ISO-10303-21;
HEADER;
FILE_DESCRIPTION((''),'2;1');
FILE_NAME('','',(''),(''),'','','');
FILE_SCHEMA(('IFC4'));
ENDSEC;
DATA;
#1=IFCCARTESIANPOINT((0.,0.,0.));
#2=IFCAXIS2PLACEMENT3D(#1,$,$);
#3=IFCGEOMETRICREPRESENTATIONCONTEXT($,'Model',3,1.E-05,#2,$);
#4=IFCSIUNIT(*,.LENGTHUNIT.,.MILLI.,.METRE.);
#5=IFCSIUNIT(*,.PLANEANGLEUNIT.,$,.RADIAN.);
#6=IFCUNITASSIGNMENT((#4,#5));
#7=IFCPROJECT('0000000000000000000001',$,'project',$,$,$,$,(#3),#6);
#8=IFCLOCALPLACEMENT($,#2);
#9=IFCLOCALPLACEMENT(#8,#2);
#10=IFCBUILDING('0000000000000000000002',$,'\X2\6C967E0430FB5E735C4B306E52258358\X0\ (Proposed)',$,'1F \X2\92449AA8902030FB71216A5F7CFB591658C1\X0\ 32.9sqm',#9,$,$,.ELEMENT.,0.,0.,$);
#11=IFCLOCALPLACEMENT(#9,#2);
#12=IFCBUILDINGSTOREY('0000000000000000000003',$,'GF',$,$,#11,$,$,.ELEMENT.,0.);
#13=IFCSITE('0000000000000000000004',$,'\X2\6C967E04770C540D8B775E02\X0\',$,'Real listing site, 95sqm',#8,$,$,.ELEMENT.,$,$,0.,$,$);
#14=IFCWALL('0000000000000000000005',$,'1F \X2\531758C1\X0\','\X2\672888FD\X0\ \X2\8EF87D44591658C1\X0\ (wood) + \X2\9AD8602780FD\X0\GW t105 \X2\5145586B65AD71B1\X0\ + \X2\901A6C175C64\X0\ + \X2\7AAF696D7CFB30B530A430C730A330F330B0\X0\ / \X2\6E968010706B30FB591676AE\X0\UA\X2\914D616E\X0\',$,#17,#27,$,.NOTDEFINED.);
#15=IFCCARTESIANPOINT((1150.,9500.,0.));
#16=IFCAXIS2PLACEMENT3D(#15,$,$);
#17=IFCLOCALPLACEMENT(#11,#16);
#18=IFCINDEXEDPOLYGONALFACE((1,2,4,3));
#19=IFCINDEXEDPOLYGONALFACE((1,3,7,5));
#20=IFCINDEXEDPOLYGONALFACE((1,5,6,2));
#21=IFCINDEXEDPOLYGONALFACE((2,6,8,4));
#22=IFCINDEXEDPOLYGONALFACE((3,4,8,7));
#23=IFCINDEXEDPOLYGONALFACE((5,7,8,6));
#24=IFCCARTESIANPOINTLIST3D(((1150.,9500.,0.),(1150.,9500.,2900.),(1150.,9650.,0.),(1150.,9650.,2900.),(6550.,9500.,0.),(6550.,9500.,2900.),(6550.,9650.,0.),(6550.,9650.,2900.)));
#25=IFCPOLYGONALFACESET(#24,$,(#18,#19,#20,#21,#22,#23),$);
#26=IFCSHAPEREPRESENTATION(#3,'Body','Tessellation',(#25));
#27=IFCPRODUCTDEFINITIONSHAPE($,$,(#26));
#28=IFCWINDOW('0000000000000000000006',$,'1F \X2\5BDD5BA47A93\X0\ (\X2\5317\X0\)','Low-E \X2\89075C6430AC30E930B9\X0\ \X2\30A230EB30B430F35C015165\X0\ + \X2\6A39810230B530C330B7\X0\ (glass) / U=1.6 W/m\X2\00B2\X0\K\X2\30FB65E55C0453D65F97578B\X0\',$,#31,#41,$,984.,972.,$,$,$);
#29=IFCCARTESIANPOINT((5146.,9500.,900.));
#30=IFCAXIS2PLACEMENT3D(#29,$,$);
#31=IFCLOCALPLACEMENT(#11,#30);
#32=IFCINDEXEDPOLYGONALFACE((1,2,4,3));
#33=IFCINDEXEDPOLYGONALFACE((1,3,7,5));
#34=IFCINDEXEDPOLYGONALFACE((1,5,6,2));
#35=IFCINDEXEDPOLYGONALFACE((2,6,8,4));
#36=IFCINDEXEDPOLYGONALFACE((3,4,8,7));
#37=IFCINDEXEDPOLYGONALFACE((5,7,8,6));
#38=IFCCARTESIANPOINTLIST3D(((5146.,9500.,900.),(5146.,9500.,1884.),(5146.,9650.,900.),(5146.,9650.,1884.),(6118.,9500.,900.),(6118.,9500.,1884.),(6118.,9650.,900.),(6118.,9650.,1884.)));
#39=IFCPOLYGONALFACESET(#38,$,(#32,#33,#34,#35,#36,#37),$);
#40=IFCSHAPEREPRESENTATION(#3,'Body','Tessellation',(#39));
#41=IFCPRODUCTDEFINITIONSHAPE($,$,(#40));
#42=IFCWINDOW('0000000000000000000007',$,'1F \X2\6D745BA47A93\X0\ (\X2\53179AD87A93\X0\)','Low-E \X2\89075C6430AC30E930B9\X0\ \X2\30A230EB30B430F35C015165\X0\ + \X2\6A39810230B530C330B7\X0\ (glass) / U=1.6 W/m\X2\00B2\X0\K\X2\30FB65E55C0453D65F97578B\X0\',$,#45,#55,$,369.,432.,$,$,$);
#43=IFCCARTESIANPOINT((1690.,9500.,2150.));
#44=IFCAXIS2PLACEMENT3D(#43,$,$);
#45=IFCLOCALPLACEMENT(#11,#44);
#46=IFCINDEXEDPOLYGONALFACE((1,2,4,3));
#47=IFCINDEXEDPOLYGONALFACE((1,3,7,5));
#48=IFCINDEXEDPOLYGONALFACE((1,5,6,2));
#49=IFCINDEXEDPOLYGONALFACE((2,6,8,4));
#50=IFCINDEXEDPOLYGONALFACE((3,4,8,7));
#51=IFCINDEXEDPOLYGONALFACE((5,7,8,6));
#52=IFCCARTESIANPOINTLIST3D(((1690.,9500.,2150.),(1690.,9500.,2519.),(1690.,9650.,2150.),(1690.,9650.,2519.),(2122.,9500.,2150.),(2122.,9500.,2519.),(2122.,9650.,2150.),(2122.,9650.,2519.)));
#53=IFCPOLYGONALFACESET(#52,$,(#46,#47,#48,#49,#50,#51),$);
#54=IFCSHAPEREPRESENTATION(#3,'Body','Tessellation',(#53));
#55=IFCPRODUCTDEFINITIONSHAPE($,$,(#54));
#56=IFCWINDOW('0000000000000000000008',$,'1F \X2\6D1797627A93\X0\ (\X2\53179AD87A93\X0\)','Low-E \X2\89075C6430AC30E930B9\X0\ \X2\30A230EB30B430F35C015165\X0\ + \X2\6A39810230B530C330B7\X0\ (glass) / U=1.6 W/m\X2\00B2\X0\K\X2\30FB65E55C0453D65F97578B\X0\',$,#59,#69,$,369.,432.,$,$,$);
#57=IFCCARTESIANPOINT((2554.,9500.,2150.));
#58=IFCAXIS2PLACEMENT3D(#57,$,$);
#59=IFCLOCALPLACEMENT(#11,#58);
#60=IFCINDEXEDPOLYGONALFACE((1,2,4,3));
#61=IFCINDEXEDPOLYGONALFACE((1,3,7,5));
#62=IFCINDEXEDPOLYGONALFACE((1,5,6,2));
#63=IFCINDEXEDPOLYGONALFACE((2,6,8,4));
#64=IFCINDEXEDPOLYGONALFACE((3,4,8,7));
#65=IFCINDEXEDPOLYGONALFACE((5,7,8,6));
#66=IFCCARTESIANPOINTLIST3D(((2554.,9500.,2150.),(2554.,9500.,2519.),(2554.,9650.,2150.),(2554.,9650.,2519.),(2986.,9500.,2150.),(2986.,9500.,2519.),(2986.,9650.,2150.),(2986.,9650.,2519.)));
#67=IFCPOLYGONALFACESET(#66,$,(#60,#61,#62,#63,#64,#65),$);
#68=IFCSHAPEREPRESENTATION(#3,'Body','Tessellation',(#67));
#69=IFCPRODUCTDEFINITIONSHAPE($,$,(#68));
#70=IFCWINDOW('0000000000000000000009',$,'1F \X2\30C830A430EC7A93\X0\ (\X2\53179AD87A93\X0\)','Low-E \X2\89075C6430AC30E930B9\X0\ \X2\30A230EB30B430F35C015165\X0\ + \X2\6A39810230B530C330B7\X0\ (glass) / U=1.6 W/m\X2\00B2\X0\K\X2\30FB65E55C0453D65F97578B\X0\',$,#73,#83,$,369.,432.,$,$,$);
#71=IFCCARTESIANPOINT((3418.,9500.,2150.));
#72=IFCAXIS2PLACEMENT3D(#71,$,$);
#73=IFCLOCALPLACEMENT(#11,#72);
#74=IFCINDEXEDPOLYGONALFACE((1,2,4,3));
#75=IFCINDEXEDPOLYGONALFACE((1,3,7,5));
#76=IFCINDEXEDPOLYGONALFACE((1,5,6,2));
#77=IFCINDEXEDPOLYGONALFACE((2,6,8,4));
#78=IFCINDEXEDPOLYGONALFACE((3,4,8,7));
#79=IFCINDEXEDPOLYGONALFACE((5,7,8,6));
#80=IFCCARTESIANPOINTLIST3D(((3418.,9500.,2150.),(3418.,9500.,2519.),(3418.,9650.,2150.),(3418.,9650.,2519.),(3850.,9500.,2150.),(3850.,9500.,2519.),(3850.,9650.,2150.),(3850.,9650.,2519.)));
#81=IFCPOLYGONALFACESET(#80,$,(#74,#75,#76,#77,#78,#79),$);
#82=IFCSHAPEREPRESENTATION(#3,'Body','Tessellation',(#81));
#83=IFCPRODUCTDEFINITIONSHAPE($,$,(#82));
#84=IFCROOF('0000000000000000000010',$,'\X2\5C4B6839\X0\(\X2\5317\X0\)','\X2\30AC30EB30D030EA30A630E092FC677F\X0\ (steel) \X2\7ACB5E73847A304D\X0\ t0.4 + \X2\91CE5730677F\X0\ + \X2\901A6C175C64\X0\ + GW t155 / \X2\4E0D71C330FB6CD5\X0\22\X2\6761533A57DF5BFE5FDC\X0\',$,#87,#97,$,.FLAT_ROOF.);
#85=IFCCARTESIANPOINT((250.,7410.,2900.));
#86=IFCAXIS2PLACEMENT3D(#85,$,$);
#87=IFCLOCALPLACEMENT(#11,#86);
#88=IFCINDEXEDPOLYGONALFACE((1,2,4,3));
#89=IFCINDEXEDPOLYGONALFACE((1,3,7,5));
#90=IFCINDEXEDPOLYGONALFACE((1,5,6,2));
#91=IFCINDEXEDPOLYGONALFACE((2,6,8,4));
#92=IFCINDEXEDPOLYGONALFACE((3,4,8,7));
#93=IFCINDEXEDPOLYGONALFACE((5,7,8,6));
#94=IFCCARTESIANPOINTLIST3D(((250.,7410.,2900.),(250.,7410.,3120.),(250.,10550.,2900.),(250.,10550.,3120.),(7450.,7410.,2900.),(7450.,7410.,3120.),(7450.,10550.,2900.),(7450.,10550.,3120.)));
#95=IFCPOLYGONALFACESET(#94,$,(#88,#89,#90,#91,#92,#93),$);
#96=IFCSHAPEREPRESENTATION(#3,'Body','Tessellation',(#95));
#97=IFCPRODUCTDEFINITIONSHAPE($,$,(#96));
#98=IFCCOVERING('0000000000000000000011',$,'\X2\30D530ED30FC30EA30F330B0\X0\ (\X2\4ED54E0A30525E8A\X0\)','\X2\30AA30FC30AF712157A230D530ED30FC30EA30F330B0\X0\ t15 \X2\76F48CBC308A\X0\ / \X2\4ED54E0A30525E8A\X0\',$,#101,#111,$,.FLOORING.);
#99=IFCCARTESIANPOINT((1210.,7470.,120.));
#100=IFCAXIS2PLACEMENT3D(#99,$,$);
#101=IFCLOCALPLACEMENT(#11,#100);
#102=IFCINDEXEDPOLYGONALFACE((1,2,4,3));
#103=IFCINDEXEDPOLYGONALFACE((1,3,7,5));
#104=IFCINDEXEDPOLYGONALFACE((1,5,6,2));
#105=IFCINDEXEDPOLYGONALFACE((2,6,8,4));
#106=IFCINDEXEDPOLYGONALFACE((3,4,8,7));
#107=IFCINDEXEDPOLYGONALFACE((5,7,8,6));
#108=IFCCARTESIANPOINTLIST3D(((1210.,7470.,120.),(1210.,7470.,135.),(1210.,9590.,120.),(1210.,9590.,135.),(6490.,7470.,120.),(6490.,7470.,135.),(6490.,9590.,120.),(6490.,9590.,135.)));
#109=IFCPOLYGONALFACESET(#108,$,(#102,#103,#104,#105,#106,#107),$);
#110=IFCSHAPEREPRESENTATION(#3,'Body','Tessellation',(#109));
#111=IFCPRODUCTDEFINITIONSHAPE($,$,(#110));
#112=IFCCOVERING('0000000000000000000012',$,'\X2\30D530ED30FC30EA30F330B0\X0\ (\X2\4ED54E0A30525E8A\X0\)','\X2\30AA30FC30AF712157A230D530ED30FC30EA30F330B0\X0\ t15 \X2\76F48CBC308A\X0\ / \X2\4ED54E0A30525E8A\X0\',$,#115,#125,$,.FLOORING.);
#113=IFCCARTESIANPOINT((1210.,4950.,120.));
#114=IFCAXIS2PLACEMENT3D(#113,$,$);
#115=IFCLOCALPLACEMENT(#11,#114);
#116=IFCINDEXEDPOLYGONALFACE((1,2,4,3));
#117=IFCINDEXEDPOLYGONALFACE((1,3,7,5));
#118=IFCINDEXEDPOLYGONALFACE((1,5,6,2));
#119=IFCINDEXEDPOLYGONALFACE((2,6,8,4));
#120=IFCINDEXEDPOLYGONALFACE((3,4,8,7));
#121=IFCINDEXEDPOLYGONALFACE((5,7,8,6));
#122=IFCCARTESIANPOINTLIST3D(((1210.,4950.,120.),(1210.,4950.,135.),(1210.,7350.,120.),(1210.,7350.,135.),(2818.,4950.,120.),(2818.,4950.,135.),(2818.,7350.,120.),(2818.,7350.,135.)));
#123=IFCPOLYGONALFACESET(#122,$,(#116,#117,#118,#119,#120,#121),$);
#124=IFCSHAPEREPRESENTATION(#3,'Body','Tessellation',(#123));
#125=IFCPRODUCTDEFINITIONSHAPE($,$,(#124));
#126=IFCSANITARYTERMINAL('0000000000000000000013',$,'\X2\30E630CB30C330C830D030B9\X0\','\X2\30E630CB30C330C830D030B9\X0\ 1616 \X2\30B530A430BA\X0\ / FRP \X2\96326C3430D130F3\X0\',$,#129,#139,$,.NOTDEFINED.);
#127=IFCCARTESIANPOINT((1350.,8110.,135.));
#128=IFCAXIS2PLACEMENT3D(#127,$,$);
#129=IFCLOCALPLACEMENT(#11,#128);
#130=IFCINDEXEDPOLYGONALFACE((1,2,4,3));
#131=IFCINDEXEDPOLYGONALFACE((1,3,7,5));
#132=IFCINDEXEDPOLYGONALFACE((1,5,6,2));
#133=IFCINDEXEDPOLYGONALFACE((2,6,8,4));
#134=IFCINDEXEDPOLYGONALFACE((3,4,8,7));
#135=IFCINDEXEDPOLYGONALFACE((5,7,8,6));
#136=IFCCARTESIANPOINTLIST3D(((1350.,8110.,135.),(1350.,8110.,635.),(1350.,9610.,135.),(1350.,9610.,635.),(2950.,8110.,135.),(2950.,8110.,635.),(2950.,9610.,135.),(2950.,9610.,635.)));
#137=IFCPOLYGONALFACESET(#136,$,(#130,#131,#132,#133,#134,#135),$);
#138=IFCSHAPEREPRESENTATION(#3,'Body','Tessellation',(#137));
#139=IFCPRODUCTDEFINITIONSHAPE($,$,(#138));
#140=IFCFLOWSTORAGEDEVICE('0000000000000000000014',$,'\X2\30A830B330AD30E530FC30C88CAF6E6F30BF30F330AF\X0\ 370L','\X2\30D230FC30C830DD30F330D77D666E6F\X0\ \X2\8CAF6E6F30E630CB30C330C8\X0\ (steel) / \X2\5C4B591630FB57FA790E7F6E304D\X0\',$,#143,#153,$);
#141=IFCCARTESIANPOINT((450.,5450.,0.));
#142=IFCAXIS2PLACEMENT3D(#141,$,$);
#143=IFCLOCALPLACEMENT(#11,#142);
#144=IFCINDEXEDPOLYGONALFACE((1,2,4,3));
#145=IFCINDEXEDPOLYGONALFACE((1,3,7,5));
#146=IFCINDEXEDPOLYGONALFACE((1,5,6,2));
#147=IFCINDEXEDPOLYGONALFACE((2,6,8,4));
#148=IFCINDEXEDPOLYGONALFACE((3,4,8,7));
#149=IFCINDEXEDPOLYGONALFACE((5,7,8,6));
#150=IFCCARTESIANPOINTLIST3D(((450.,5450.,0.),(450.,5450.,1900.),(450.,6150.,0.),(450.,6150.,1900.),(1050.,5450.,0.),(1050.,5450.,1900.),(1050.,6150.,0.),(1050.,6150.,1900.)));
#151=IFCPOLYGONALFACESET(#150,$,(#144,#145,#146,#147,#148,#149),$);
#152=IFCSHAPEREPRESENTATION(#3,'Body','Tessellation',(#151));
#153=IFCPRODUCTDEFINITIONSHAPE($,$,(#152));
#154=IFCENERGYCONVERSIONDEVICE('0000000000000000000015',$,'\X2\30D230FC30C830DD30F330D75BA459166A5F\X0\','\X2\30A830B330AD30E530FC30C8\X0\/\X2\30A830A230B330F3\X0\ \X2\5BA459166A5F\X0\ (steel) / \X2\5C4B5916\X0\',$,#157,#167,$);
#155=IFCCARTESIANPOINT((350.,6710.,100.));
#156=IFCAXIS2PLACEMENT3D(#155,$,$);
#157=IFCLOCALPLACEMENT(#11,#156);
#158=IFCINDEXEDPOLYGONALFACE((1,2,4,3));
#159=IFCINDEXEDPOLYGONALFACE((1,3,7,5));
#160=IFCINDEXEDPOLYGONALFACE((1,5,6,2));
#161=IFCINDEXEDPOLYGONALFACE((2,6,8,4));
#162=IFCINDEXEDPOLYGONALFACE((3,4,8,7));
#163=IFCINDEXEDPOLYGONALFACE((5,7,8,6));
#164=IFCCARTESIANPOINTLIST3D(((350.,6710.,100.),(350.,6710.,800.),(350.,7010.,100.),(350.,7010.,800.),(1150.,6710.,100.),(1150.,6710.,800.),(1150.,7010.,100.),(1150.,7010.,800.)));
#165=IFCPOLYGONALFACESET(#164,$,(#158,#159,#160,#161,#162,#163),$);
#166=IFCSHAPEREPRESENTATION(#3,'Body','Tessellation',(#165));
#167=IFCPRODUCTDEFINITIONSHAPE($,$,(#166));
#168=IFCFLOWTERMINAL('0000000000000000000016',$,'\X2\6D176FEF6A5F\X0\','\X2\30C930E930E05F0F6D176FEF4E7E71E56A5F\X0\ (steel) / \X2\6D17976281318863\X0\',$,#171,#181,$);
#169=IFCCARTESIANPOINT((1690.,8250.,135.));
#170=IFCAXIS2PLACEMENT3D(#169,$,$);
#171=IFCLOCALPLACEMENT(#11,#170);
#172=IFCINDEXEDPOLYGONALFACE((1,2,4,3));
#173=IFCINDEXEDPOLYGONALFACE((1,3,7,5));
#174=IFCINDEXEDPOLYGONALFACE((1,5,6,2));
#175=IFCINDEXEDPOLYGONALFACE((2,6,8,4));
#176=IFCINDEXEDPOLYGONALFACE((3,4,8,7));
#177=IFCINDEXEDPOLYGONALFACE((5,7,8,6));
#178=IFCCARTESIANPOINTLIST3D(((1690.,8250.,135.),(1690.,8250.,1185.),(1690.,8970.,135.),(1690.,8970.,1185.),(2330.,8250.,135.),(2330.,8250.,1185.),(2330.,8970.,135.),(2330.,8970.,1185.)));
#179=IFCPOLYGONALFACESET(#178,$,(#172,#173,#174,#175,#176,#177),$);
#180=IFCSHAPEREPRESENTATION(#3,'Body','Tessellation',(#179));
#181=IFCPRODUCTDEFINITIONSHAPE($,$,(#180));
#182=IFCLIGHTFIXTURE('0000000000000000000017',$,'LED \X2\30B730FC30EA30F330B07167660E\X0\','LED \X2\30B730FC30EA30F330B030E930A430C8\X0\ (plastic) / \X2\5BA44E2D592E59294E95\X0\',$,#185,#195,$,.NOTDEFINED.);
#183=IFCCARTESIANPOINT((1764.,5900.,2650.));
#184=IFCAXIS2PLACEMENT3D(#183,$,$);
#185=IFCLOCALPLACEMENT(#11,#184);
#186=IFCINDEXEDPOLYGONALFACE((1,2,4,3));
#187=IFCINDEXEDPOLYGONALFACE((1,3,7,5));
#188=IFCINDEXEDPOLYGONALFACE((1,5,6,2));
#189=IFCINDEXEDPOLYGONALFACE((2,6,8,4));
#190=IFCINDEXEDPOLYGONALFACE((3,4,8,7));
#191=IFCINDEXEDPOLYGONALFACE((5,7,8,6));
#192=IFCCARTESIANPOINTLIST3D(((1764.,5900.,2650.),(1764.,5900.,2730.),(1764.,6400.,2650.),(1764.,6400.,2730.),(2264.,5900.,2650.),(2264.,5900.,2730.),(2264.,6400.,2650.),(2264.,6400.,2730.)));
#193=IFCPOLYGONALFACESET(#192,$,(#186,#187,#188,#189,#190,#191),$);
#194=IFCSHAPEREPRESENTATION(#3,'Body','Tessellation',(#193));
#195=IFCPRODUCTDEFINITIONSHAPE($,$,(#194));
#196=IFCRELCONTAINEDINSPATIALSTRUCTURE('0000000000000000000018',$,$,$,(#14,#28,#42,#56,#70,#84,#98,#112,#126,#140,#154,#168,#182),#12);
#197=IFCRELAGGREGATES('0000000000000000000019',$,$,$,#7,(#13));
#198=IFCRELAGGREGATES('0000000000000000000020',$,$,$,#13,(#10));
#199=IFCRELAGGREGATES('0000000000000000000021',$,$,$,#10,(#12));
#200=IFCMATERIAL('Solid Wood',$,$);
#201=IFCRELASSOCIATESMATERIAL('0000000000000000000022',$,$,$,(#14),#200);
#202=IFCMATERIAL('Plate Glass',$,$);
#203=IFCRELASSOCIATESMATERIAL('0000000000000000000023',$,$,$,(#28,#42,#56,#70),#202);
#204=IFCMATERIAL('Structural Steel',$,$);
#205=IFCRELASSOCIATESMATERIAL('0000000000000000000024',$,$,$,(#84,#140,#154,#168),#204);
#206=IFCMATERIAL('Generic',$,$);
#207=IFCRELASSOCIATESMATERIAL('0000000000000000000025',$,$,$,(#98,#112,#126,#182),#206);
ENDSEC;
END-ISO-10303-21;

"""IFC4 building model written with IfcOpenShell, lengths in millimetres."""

from ifc_helpers import new_model, si_unit, frame, frame_2d, origin, place, context, project, spatial, rectangle, extrude, material, element, fill, save


model = new_model("IFC4")

# Units and contexts
model_context = context("Model", 3, precision=1e-05, world=origin())
ifc_project = project(units=[si_unit("LENGTHUNIT", "METRE", prefix="MILLI"), si_unit("PLANEANGLEUNIT", "RADIAN")], contexts=[model_context])

# Site, building, storey
site_placement = place(None, origin())
site = spatial("IfcSite", under=ifc_project, at=site_placement, Name="沖縄県名護市", ObjectType="Real listing site, 95sqm", CompositionType="ELEMENT", RefElevation=0.0)
building_placement = place(site_placement, origin())
building = spatial("IfcBuilding", under=site, at=building_placement, Name="沖縄・平屋の別荘 (Proposed)", ObjectType="1F 鉄骨造・無機系外壁 32.9sqm", CompositionType="ELEMENT", ElevationOfRefHeight=0.0, ElevationOfTerrain=0.0)
storey_placement = place(building_placement, origin())
storey = spatial("IfcBuildingStorey", under=building, at=storey_placement, Name="GF", CompositionType="ELEMENT", Elevation=0.0)

# Shared definitions
ifc_material_1 = material(Name="Solid Wood")

# Wall, openings, windows
wall_1_placement = place(storey_placement, frame((1150.0, 9500.0, 0.0)))
wall_1 = element("IfcWall", 1, at=wall_1_placement, inside=storey, material=ifc_material_1, Name="1F 北壁", Description="木製 軸組外壁 (wood) + 高性能GW t105 充填断熱 + 通気層 + 窯業系サイディング / 準耐火・外皮UA配慮", PredefinedType="NOTDEFINED", context=model_context, shape_type="SweptSolid", body=[
    extrude(rectangle(XDim=5400.0, YDim=150.0, at=frame_2d((2700.0, 75.0))), frame((1150.0, 9500.0, 0.0)), (0.0, 0.0, 1.0), 2900.0),
])
opening_1_placement = place(storey_placement, frame((5146.0, 9500.0, 900.0)))
opening_1 = element("IfcOpeningElement", 2, at=opening_1_placement, cuts=wall_1, PredefinedType="NOTDEFINED", context=model_context, shape_type="SweptSolid", body=[
    extrude(rectangle(XDim=972.0, YDim=150.0, at=frame_2d((486.0, 75.0))), frame((5146.0, 9500.0, 900.0)), (0.0, 0.0, 1.0), 984.0),
])
opening_2_placement = place(storey_placement, frame((1690.0, 9500.0, 2150.0)))
opening_2 = element("IfcOpeningElement", 3, at=opening_2_placement, cuts=wall_1, PredefinedType="NOTDEFINED", context=model_context, shape_type="SweptSolid", body=[
    extrude(rectangle(XDim=432.0, YDim=150.0, at=frame_2d((216.0, 75.0))), frame((1690.0, 9500.0, 2150.0)), (0.0, 0.0, 1.0), 369.0),
])
opening_3_placement = place(storey_placement, frame((2554.0, 9500.0, 2150.0)))
opening_3 = element("IfcOpeningElement", 4, at=opening_3_placement, cuts=wall_1, PredefinedType="NOTDEFINED", context=model_context, shape_type="SweptSolid", body=[
    extrude(rectangle(XDim=432.0, YDim=150.0, at=frame_2d((216.0, 75.0))), frame((2554.0, 9500.0, 2150.0)), (0.0, 0.0, 1.0), 369.0),
])
opening_4_placement = place(storey_placement, frame((3418.0, 9500.0, 2150.0)))
opening_4 = element("IfcOpeningElement", 5, at=opening_4_placement, cuts=wall_1, PredefinedType="NOTDEFINED", context=model_context, shape_type="SweptSolid", body=[
    extrude(rectangle(XDim=432.0, YDim=150.0, at=frame_2d((216.0, 75.0))), frame((3418.0, 9500.0, 2150.0)), (0.0, 0.0, 1.0), 369.0),
])
ifc_material_2 = material(Name="Plate Glass")
window_1_placement = place(storey_placement, frame((5146.0, 9500.0, 900.0)))
window_1 = element("IfcWindow", 6, at=window_1_placement, inside=storey, material=ifc_material_2, Name="1F 寝室窓 (北)", Description="Low-E 複層ガラス アルゴン封入 + 樹脂サッシ (glass) / U=1.6 W/m²K・日射取得型", OverallHeight=984.0, OverallWidth=972.0, context=model_context, shape_type="SweptSolid", body=[
    extrude(rectangle(XDim=972.0, YDim=150.0, at=frame_2d((486.0, 75.0))), frame((5146.0, 9500.0, 900.0)), (0.0, 0.0, 1.0), 984.0),
])
fill(opening_1, window_1)
window_2_placement = place(storey_placement, frame((1690.0, 9500.0, 2150.0)))
window_2 = element("IfcWindow", 7, at=window_2_placement, inside=storey, material=ifc_material_2, Name="1F 浴室窓 (北高窓)", Description="Low-E 複層ガラス アルゴン封入 + 樹脂サッシ (glass) / U=1.6 W/m²K・日射取得型", OverallHeight=369.0, OverallWidth=432.0, context=model_context, shape_type="SweptSolid", body=[
    extrude(rectangle(XDim=432.0, YDim=150.0, at=frame_2d((216.0, 75.0))), frame((1690.0, 9500.0, 2150.0)), (0.0, 0.0, 1.0), 369.0),
])
fill(opening_2, window_2)
window_3_placement = place(storey_placement, frame((2554.0, 9500.0, 2150.0)))
window_3 = element("IfcWindow", 8, at=window_3_placement, inside=storey, material=ifc_material_2, Name="1F 洗面窓 (北高窓)", Description="Low-E 複層ガラス アルゴン封入 + 樹脂サッシ (glass) / U=1.6 W/m²K・日射取得型", OverallHeight=369.0, OverallWidth=432.0, context=model_context, shape_type="SweptSolid", body=[
    extrude(rectangle(XDim=432.0, YDim=150.0, at=frame_2d((216.0, 75.0))), frame((2554.0, 9500.0, 2150.0)), (0.0, 0.0, 1.0), 369.0),
])
fill(opening_3, window_3)
window_4_placement = place(storey_placement, frame((3418.0, 9500.0, 2150.0)))
window_4 = element("IfcWindow", 9, at=window_4_placement, inside=storey, material=ifc_material_2, Name="1F トイレ窓 (北高窓)", Description="Low-E 複層ガラス アルゴン封入 + 樹脂サッシ (glass) / U=1.6 W/m²K・日射取得型", OverallHeight=369.0, OverallWidth=432.0, context=model_context, shape_type="SweptSolid", body=[
    extrude(rectangle(XDim=432.0, YDim=150.0, at=frame_2d((216.0, 75.0))), frame((3418.0, 9500.0, 2150.0)), (0.0, 0.0, 1.0), 369.0),
])
fill(opening_4, window_4)

# Roof
ifc_material_3 = material(Name="Structural Steel")
roof_placement = place(storey_placement, frame((250.0, 7410.0, 2900.0)))
element("IfcRoof", 10, at=roof_placement, inside=storey, material=ifc_material_3, Name="屋根(北)", Description="ガルバリウム鋼板 (steel) 立平葺き t0.4 + 野地板 + 通気層 + GW t155 / 不燃・法22条区域対応", PredefinedType="FLAT_ROOF", context=model_context, shape_type="SweptSolid", body=[
    extrude(rectangle(XDim=7200.0, YDim=3140.0, at=frame_2d((3600.0, 1570.0))), frame((250.0, 7410.0, 2900.0)), (0.0, 0.0, 1.0), 220.0),
])

# Coverings
ifc_material_4 = material(Name="Generic")
covering_1_placement = place(storey_placement, frame((1210.0, 7470.0, 120.0)))
element("IfcCovering", 11, at=covering_1_placement, inside=storey, material=ifc_material_4, Name="フローリング (仕上げ床)", Description="オーク無垢フローリング t15 直貼り / 仕上げ床", PredefinedType="FLOORING", context=model_context, shape_type="SweptSolid", body=[
    extrude(rectangle(XDim=5280.0, YDim=2120.0, at=frame_2d((2640.0, 1060.0))), frame((1210.0, 7470.0, 120.0)), (0.0, 0.0, 1.0), 15.0),
])
covering_2_placement = place(storey_placement, frame((1210.0, 4950.0, 120.0)))
element("IfcCovering", 12, at=covering_2_placement, inside=storey, material=ifc_material_4, Name="フローリング (仕上げ床)", Description="オーク無垢フローリング t15 直貼り / 仕上げ床", PredefinedType="FLOORING", context=model_context, shape_type="SweptSolid", body=[
    extrude(rectangle(XDim=1608.0, YDim=2400.0, at=frame_2d((804.0, 1200.0))), frame((1210.0, 4950.0, 120.0)), (0.0, 0.0, 1.0), 15.0),
])

# Sanitary terminal
sanitary_terminal_placement = place(storey_placement, frame((1350.0, 8110.0, 135.0)))
element("IfcSanitaryTerminal", 13, at=sanitary_terminal_placement, inside=storey, material=ifc_material_4, Name="ユニットバス", Description="ユニットバス 1616 サイズ / FRP 防水パン", PredefinedType="NOTDEFINED", context=model_context, shape_type="SweptSolid", body=[
    extrude(rectangle(XDim=1600.0, YDim=1500.0, at=frame_2d((800.0, 750.0))), frame((1350.0, 8110.0, 135.0)), (0.0, 0.0, 1.0), 500.0),
])

# Flow storage device
flow_storage_device_placement = place(storey_placement, frame((450.0, 5450.0, 0.0)))
element("IfcFlowStorageDevice", 14, at=flow_storage_device_placement, inside=storey, material=ifc_material_3, Name="エコキュート貯湯タンク 370L", Description="ヒートポンプ給湯 貯湯ユニット (steel) / 屋外・基礎置き", context=model_context, shape_type="SweptSolid", body=[
    extrude(rectangle(XDim=600.0, YDim=700.0, at=frame_2d((300.0, 350.0))), frame((450.0, 5450.0, 0.0)), (0.0, 0.0, 1.0), 1900.0),
])

# Energy conversion device
energy_conversion_device_placement = place(storey_placement, frame((350.0, 6710.0, 100.0)))
element("IfcEnergyConversionDevice", 15, at=energy_conversion_device_placement, inside=storey, material=ifc_material_3, Name="ヒートポンプ室外機", Description="エコキュート/エアコン 室外機 (steel) / 屋外", context=model_context, shape_type="SweptSolid", body=[
    extrude(rectangle(XDim=800.0, YDim=300.0, at=frame_2d((400.0, 150.0))), frame((350.0, 6710.0, 100.0)), (0.0, 0.0, 1.0), 700.0),
])

# Flow terminal
flow_terminal_placement = place(storey_placement, frame((1690.0, 8250.0, 135.0)))
element("IfcFlowTerminal", 16, at=flow_terminal_placement, inside=storey, material=ifc_material_3, Name="洗濯機", Description="ドラム式洗濯乾燥機 (steel) / 洗面脱衣", context=model_context, shape_type="SweptSolid", body=[
    extrude(rectangle(XDim=640.0, YDim=720.0, at=frame_2d((320.0, 360.0))), frame((1690.0, 8250.0, 135.0)), (0.0, 0.0, 1.0), 1050.0),
])

# Light fixture
light_fixture_placement = place(storey_placement, frame((1764.0, 5900.0, 2650.0)))
element("IfcLightFixture", 17, at=light_fixture_placement, inside=storey, material=ifc_material_4, Name="LED シーリング照明", Description="LED シーリングライト (plastic) / 室中央天井", PredefinedType="NOTDEFINED", context=model_context, shape_type="SweptSolid", body=[
    extrude(rectangle(XDim=500.0, YDim=500.0, at=frame_2d((250.0, 250.0))), frame((1764.0, 5900.0, 2650.0)), (0.0, 0.0, 1.0), 80.0),
])

save(model, "model.ifc")
